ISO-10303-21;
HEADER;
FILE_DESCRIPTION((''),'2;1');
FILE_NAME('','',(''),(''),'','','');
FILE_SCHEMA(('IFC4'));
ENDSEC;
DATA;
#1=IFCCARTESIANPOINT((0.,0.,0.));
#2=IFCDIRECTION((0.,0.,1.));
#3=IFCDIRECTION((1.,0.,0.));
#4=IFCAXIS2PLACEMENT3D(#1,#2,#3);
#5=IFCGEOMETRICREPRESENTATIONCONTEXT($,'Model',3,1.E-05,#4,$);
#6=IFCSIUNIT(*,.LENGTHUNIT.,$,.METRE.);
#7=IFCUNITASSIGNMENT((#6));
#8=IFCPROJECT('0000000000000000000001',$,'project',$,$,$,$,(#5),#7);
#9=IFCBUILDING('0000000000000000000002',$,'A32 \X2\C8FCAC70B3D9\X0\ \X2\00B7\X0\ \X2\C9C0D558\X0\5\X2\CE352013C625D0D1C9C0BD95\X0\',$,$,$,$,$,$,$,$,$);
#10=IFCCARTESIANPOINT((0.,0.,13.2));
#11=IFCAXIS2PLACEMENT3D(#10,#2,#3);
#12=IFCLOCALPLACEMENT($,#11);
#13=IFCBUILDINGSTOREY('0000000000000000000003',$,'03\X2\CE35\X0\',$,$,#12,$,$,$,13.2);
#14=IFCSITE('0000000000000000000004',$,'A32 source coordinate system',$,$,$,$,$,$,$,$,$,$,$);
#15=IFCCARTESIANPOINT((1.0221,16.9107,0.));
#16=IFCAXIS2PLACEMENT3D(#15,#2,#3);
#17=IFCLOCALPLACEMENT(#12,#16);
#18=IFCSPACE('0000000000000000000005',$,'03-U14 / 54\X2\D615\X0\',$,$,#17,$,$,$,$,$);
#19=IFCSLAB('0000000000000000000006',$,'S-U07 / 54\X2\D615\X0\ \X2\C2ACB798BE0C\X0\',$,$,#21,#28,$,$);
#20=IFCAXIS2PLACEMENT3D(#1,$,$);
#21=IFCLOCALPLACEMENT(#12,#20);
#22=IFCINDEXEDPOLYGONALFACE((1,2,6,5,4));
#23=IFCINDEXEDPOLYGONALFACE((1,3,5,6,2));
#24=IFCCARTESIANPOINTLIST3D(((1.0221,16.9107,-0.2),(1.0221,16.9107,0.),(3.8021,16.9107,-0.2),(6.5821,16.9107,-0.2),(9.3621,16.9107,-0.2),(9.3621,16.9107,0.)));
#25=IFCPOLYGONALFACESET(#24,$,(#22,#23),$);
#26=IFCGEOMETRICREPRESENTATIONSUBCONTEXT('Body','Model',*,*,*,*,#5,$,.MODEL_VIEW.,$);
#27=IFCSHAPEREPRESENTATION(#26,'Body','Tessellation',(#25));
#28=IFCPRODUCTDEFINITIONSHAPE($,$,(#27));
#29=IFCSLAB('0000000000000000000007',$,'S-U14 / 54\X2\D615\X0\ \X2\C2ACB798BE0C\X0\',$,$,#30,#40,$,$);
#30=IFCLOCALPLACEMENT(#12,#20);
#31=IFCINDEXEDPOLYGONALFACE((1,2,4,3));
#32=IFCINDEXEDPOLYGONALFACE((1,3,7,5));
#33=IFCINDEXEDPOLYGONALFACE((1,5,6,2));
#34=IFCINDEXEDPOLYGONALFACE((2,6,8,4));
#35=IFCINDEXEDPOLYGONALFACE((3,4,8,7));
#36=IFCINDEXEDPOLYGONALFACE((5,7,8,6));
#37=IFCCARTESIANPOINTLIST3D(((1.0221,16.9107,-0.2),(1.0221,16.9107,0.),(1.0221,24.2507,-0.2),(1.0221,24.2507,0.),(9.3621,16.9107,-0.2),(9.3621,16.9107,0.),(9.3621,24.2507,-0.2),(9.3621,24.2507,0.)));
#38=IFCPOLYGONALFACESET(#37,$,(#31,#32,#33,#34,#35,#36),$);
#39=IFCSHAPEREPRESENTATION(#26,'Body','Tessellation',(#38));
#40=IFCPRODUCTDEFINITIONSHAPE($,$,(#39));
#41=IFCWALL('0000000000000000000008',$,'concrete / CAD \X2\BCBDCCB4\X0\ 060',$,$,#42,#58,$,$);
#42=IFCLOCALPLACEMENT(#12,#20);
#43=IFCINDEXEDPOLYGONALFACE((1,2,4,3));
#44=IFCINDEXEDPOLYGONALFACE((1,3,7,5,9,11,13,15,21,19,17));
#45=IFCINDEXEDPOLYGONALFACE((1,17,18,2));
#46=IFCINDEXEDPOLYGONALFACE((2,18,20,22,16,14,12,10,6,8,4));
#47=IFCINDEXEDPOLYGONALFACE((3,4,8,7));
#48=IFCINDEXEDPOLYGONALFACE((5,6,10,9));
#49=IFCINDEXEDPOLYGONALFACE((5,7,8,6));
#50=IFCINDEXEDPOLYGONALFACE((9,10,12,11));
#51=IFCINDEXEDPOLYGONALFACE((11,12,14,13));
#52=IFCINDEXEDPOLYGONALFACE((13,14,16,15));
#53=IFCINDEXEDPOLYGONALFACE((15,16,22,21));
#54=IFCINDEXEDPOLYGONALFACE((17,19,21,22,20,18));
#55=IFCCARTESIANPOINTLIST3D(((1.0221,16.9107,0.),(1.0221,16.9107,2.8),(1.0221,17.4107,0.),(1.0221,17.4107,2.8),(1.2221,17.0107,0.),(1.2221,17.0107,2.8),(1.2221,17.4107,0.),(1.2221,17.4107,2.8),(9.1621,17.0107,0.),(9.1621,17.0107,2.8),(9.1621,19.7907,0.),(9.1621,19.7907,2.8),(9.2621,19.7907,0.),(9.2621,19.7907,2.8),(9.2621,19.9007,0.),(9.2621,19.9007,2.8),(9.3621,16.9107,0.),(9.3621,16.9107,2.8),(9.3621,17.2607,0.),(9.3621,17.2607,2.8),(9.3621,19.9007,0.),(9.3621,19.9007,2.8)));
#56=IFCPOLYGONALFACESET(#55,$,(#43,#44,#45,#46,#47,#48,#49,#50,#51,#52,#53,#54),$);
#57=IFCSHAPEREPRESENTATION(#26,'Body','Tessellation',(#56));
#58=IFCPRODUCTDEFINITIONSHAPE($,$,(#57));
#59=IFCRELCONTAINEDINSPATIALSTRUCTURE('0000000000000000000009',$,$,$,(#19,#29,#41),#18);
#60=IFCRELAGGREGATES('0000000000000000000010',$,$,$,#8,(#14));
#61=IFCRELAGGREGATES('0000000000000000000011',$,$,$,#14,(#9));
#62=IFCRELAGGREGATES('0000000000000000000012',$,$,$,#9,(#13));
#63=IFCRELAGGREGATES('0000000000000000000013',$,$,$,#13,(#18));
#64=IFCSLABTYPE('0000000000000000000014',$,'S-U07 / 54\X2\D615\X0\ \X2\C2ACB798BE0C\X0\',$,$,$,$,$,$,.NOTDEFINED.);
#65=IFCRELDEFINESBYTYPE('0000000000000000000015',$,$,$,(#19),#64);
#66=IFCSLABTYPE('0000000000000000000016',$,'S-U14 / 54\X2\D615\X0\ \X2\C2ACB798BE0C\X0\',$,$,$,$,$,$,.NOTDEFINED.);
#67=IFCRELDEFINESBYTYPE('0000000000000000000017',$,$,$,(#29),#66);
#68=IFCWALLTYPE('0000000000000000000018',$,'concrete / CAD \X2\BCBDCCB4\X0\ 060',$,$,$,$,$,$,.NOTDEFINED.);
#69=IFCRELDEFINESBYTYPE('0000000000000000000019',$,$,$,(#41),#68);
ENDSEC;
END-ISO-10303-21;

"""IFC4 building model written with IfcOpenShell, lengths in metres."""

from ifc_helpers import new_model, si_unit, frame, origin, origin_with_axes, place, context, subcontext, project, spatial, polyline, outline, extrude, source, transform, mapped, type_object, type_shapes, element, save


model = new_model("IFC4")

# Units and contexts
model_context = context("Model", 3, precision=1e-05, world=origin_with_axes())
body_context = subcontext(model_context, "Body", "Model", "MODEL_VIEW")
ifc_project = project(units=[si_unit("LENGTHUNIT", "METRE")], contexts=[model_context])

# Site, building, storey, space
storey_placement = place(None, frame((0.0, 0.0, 13.2), z_axis=(0.0, 0.0, 1.0), x_axis=(1.0, 0.0, 0.0)))
space_placement = place(storey_placement, frame((1.0221, 16.9107, 0.0), z_axis=(0.0, 0.0, 1.0), x_axis=(1.0, 0.0, 0.0)))
site = spatial("IfcSite", under=ifc_project, Name="A32 source coordinate system")
building = spatial("IfcBuilding", under=site, Name="A32 주거동 · 지하5층–옥탑지붕")
storey = spatial("IfcBuildingStorey", under=building, at=storey_placement, Name="03층", Elevation=13.2)
space = spatial("IfcSpace", under=storey, at=space_placement, Name="03-U14 / 54형")

# Slabs
slab_type_1 = type_object("IfcSlabType", Name="S-U07 / 54형 슬래브", PredefinedType="NOTDEFINED")
shared_shape_1 = source(origin(), body_context, "Body", "SweptSolid", [
    extrude(outline(polyline([(0.0, 0.0), (0.0, 0.0), (8.34, 0.0), (8.34, 0.0), (0.0, 0.0)])), frame((0.0, 0.0, -0.2)), (0.0, 0.0, 1.0), 0.2),
])
type_shapes(slab_type_1, [shared_shape_1])
slab_1_placement = place(space_placement, origin_with_axes())
element("IfcSlab", 1, at=slab_1_placement, inside=space, type_object=slab_type_1, Name="S-U07 / 54형 슬래브", context=body_context, shape_type="MappedRepresentation", body=[
    mapped(shared_shape_1, transform((0.0, 0.0, 0.0), scale=1.0)),
])
slab_type_2 = type_object("IfcSlabType", Name="S-U14 / 54형 슬래브", PredefinedType="NOTDEFINED")
shared_shape_2 = source(origin(), body_context, "Body", "SweptSolid", [
    extrude(outline(polyline([(0.0, 0.0), (0.0, 7.34), (8.34, 7.34), (8.34, 0.0), (0.0, 0.0)])), frame((0.0, 0.0, -0.2)), (0.0, 0.0, 1.0), 0.2),
])
type_shapes(slab_type_2, [shared_shape_2])
slab_2_placement = place(space_placement, origin_with_axes())
element("IfcSlab", 2, at=slab_2_placement, inside=space, type_object=slab_type_2, Name="S-U14 / 54형 슬래브", context=body_context, shape_type="MappedRepresentation", body=[
    mapped(shared_shape_2, transform((0.0, 0.0, 0.0), scale=1.0)),
])

# Wall
wall_type_1 = type_object("IfcWallType", Name="concrete / CAD 벽체 060", PredefinedType="NOTDEFINED")
shared_shape_3 = source(origin(), body_context, "Body", "SweptSolid", [
    extrude(outline(polyline([(0.2, 0.5), (0.2, 0.1), (8.14, 0.1), (8.14, 2.88), (8.24, 2.88), (8.24, 2.99), (8.34, 2.99), (8.34, 0.35), (8.34, 0.35), (8.34, 0.0), (0.0, 0.0), (0.0, 0.5), (0.2, 0.5)])), origin(), (0.0, 0.0, 1.0), 2.8),
])
type_shapes(wall_type_1, [shared_shape_3])
wall_1_placement = place(space_placement, origin_with_axes())
element("IfcWall", 3, at=wall_1_placement, inside=space, type_object=wall_type_1, Name="concrete / CAD 벽체 060", context=body_context, shape_type="MappedRepresentation", body=[
    mapped(shared_shape_3, transform((0.0, 0.0, 0.0), scale=1.0)),
])

save(model, "model.ifc")
